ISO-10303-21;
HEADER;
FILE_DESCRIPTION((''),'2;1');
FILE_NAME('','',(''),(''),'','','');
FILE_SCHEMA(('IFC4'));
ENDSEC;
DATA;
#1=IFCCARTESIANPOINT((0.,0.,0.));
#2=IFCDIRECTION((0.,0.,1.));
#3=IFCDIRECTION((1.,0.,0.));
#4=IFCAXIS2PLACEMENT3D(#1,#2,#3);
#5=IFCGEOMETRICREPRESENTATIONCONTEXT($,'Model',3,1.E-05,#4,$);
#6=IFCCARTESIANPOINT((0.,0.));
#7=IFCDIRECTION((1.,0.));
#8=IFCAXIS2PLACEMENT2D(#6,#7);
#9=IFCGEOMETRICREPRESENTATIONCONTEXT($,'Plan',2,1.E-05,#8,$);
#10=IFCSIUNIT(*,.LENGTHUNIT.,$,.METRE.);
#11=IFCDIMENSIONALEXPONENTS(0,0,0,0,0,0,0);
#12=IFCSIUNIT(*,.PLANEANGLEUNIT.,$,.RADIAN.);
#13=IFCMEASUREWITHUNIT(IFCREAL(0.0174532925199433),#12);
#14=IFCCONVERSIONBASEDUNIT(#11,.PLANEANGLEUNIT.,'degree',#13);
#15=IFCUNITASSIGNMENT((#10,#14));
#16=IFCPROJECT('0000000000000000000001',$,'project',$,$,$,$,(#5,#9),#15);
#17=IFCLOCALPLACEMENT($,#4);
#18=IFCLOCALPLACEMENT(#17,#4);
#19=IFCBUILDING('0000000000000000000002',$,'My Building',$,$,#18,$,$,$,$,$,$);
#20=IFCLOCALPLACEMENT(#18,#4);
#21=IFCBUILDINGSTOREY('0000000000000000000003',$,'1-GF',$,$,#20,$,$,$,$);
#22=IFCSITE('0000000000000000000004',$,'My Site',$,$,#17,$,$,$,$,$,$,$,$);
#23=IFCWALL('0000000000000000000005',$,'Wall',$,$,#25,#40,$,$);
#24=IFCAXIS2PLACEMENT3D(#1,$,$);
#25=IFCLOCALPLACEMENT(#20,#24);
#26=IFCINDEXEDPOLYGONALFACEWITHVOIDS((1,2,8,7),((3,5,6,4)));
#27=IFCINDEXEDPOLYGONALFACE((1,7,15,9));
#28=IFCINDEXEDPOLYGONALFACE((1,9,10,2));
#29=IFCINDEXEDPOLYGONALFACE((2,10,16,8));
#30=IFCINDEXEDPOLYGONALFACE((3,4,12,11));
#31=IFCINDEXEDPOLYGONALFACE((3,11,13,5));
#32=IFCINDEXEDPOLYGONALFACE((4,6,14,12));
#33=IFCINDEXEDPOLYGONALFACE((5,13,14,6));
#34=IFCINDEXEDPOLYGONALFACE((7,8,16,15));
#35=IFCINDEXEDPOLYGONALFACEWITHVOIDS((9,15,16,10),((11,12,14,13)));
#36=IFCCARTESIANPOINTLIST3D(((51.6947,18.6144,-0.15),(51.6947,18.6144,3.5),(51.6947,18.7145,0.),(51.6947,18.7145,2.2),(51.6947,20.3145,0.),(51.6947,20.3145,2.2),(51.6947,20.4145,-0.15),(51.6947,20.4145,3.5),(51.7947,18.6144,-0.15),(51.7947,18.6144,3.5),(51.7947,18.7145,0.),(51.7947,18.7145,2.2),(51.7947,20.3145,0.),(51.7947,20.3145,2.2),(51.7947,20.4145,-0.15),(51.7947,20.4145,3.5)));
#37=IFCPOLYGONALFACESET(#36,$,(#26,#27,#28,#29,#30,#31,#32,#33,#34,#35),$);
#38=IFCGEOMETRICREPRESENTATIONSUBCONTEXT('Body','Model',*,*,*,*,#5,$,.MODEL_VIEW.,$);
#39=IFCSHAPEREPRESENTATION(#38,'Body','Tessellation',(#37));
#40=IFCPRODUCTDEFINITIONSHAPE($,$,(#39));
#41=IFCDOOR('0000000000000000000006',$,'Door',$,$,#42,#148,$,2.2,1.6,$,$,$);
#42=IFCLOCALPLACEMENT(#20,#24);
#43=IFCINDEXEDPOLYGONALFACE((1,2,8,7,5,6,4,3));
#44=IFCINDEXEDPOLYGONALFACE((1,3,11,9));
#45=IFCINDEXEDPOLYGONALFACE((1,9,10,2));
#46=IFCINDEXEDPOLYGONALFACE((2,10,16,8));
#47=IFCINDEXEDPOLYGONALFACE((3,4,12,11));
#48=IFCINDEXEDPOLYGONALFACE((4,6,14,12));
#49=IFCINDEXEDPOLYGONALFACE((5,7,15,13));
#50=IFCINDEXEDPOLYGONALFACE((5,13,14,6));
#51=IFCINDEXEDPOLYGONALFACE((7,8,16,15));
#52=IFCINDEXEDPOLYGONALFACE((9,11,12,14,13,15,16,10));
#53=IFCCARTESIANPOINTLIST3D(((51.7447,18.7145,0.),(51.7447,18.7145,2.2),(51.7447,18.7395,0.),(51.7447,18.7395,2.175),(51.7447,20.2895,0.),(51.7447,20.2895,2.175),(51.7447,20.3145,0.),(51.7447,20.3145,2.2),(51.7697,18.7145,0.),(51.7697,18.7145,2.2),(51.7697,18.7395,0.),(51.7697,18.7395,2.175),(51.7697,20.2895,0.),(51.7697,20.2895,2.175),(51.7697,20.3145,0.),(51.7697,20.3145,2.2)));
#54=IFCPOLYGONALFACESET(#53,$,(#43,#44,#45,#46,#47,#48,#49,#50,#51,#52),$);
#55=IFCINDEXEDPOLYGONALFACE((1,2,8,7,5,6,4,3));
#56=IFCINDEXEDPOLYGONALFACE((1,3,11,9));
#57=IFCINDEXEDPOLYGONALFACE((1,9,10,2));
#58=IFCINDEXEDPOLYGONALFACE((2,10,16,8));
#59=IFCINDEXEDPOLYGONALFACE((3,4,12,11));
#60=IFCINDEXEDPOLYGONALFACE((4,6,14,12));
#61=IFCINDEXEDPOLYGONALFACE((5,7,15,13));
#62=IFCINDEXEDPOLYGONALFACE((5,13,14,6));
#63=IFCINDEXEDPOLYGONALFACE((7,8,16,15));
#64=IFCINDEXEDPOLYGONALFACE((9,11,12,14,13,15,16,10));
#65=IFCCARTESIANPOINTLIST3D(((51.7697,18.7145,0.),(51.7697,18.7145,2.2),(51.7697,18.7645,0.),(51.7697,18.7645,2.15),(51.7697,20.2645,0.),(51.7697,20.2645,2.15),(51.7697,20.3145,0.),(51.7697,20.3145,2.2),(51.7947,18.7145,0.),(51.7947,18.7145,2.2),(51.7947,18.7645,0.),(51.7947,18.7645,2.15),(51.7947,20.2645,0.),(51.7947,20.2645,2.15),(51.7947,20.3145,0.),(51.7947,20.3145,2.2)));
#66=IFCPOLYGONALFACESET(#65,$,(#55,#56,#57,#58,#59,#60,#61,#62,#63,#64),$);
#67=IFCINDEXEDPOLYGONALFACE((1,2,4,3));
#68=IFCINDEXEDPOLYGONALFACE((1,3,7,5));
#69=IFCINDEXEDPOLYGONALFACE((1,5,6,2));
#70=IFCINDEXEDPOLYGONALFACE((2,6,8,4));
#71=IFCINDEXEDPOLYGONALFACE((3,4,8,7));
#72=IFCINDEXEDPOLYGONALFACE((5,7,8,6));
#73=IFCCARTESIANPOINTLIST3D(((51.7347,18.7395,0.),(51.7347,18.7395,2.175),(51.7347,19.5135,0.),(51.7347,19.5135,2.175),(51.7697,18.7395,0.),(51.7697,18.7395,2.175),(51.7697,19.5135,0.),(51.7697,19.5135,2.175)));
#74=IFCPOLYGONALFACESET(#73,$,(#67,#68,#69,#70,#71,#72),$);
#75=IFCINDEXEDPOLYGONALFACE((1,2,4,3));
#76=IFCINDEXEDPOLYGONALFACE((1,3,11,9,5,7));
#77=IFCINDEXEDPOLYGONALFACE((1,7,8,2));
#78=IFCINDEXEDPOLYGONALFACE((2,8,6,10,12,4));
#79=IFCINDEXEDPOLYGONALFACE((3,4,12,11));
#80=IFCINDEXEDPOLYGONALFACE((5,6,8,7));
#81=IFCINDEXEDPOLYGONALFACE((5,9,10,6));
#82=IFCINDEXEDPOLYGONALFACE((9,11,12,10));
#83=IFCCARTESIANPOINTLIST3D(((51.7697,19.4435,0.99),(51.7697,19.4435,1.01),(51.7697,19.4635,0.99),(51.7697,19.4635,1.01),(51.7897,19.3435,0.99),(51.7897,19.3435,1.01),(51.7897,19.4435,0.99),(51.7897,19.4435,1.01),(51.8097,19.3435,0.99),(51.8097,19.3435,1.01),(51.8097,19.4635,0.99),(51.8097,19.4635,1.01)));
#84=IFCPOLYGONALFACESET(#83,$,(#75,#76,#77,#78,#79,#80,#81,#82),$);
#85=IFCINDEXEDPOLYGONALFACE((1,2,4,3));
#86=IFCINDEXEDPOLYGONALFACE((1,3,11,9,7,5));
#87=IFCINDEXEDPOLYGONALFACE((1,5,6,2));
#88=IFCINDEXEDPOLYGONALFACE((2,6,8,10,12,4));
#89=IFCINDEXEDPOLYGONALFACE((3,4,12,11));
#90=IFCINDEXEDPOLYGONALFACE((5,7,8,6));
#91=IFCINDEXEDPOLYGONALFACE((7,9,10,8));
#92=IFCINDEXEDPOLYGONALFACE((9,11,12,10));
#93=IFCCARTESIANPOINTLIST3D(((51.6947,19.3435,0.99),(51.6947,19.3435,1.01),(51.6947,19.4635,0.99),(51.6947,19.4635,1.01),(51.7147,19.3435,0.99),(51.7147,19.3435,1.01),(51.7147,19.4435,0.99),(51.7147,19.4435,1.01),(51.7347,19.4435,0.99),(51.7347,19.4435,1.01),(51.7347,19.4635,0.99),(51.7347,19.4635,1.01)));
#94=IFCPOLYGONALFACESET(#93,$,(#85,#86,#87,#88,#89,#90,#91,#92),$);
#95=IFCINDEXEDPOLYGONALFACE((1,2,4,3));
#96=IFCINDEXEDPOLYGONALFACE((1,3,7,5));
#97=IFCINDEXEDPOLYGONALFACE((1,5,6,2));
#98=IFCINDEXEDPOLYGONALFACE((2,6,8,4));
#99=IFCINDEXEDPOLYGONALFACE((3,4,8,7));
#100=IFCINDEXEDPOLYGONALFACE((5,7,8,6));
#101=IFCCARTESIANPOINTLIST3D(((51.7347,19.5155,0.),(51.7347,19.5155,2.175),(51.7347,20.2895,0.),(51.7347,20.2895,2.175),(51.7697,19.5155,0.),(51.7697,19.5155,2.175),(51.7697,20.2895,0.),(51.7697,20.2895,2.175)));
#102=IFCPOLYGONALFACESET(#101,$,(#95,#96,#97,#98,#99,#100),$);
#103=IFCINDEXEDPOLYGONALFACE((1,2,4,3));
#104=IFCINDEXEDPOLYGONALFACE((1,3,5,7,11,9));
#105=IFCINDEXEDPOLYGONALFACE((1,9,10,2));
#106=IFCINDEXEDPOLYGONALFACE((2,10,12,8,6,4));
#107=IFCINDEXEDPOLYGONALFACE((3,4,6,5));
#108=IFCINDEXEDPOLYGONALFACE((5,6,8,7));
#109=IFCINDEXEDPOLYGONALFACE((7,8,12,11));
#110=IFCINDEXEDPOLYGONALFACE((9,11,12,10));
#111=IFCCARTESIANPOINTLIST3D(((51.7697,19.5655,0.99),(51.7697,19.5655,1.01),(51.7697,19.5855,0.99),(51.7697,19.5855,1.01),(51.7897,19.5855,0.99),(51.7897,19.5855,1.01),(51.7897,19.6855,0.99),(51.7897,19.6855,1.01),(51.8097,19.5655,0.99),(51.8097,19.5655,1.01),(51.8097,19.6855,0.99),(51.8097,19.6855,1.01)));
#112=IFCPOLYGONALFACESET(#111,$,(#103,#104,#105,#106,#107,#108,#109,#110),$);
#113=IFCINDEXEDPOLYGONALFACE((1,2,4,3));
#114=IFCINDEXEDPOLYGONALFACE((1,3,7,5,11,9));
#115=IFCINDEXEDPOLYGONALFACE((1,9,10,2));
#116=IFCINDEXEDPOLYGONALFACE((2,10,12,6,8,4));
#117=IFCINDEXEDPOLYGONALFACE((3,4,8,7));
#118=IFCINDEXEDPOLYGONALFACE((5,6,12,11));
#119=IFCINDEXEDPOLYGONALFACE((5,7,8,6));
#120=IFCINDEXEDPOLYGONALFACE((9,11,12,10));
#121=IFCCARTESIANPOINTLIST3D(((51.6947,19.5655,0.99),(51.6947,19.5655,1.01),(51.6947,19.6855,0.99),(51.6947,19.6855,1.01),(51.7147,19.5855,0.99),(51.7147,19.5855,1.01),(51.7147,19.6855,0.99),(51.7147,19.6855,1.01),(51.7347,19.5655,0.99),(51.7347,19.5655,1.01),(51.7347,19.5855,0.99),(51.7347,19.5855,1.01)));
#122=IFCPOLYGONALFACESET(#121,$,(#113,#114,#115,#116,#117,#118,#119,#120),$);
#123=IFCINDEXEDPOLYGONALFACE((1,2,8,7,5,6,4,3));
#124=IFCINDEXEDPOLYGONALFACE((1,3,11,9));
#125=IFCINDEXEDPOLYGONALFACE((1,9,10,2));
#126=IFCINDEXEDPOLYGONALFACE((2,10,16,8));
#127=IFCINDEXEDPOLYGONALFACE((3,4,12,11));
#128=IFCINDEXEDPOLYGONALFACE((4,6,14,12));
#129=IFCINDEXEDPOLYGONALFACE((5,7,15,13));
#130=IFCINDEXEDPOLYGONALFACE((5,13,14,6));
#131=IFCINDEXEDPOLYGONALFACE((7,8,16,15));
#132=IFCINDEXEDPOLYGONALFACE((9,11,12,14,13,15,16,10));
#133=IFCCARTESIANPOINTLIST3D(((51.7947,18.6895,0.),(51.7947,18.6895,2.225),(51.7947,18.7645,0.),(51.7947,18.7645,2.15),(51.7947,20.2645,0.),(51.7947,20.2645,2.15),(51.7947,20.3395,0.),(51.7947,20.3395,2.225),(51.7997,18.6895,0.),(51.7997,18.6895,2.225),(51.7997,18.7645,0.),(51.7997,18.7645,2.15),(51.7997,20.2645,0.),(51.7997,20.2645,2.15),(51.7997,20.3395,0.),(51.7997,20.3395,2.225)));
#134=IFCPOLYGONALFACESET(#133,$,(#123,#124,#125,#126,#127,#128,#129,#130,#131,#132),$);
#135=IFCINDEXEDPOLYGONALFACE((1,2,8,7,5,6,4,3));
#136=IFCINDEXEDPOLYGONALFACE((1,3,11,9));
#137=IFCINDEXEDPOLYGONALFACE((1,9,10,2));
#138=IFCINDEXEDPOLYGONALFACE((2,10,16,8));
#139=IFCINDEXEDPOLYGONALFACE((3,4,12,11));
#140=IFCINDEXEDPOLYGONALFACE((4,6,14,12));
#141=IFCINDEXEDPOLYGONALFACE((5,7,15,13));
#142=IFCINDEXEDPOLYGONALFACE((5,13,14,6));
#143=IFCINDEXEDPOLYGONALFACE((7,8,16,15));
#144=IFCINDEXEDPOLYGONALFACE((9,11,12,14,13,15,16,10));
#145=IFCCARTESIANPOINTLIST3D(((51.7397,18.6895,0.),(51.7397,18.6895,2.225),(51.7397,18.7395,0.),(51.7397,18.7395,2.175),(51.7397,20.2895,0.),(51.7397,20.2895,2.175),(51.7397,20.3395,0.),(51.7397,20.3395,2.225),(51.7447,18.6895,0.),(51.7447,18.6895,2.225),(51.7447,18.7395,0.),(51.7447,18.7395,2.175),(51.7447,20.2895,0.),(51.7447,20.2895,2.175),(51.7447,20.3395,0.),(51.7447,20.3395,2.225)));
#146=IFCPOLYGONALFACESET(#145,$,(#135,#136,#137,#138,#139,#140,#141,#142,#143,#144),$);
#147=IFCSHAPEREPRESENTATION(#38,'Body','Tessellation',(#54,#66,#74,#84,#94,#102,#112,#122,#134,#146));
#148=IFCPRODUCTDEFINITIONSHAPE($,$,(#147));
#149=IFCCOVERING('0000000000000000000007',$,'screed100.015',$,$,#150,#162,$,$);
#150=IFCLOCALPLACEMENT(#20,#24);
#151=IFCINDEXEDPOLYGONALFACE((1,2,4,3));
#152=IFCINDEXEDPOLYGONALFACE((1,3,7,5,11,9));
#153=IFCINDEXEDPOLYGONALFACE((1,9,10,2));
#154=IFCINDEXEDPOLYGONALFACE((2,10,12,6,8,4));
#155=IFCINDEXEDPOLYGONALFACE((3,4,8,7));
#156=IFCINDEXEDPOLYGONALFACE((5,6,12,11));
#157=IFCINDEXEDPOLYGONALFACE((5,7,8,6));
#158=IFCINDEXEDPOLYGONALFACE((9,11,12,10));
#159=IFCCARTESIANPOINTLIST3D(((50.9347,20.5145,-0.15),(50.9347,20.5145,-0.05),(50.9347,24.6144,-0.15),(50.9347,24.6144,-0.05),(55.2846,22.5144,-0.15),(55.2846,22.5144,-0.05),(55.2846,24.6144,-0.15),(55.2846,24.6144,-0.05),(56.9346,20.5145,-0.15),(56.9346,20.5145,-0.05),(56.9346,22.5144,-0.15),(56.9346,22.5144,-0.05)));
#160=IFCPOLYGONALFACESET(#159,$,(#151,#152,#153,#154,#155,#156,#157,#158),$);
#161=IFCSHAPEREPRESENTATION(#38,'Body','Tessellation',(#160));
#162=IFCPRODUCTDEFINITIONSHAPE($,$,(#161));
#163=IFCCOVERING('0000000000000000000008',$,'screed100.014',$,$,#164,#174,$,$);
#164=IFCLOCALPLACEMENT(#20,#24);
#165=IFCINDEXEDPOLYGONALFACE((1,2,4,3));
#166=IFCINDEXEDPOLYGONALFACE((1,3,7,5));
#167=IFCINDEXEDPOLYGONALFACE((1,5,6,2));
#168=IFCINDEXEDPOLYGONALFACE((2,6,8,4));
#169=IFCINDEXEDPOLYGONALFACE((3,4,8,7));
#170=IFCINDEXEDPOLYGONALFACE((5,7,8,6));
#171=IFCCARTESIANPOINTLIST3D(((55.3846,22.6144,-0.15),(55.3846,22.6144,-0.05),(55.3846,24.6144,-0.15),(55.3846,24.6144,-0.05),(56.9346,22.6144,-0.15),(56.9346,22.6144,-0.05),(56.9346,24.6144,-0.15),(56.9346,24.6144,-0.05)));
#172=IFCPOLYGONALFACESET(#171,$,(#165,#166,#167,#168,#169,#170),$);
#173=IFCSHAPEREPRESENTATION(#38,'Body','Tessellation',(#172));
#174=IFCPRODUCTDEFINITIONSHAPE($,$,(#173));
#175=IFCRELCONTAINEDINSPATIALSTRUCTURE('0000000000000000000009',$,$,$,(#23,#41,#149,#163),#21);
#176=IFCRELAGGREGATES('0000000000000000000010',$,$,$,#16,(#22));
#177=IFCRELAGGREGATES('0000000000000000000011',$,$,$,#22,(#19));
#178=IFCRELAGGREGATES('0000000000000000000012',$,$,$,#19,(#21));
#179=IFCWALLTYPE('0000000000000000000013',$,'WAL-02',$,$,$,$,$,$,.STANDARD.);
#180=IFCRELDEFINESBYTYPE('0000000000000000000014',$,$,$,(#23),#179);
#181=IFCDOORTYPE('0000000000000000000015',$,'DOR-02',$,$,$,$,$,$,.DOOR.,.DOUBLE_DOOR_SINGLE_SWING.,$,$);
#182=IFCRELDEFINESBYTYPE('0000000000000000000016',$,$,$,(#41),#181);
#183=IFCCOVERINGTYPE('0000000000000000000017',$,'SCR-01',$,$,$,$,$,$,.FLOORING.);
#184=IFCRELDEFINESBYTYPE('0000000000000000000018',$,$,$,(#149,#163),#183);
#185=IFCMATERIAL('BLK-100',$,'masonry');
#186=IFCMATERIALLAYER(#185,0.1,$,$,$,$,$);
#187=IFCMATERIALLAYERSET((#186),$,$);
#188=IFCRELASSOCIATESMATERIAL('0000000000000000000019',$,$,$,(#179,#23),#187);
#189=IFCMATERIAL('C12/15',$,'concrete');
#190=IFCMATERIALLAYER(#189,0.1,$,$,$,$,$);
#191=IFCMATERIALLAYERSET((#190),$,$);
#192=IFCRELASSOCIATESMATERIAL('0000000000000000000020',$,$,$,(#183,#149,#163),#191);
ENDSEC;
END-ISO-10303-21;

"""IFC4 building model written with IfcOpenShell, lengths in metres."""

from ifc_helpers import new_model, entity, si_unit, converted_unit, frame, origin_with_axes, origin_2d_with_axis, place, context, subcontext, project, spatial, line, indexed_curve, outline, extrude, shape, source, transform, mapped, material, layer, layer_set, layer_usage, type_object, type_shapes, element, fill, save


model = new_model("IFC4")

# Units and contexts
model_context = context("Model", 3, precision=1e-05, world=origin_with_axes())
plan_context = context("Plan", 2, precision=1e-05, world=origin_2d_with_axis())
body_context_1 = subcontext(model_context, "Body", "Model", "MODEL_VIEW")
body_context_2 = subcontext(plan_context, "Body", "Plan", "PLAN_VIEW")
ifc_project = project(units=[si_unit("LENGTHUNIT", "METRE"), converted_unit("PLANEANGLEUNIT", "degree", entity("IfcReal", 0.0174532925199433), si_unit("PLANEANGLEUNIT", "RADIAN"), dimensions=[0, 0, 0, 0, 0, 0, 0])], contexts=[model_context, plan_context])

# Site, building, storey
site_placement = place(None, origin_with_axes())
site = spatial("IfcSite", under=ifc_project, at=site_placement, Name="My Site")
building_placement = place(site_placement, origin_with_axes())
building = spatial("IfcBuilding", under=site, at=building_placement, Name="My Building")
storey_placement = place(building_placement, origin_with_axes())
storey = spatial("IfcBuildingStorey", under=building, at=storey_placement, Name="1-GF")

# Shared definitions
ifc_material_1 = material(Name="BLK-100", Category="masonry")
ifc_layer_1 = layer(ifc_material_1, 0.1)
ifc_layer_set_1 = layer_set([ifc_layer_1])
wall_type_1 = type_object("IfcWallType", Name="WAL-02", PredefinedType="STANDARD", material=ifc_layer_set_1)

# Wall, opening, door
ifc_layer_usage_1 = layer_usage(ifc_layer_set_1, "AXIS2", "POSITIVE", 0.0)
wall_1_placement = place(storey_placement, frame((51.7947, 18.6144, -0.15), z_axis=(0.0, 0.0, 1.0), x_axis=(0.0, 1.0, 0.0)))
wall_1 = element("IfcWall", 1, at=wall_1_placement, inside=storey, type_object=wall_type_1, material=ifc_layer_usage_1, Name="Wall", context=body_context_1, shape_type="SweptSolid", body=[
    extrude(outline(indexed_curve([(0.0, 0.0), (0.0, 0.1), (1.8001, 0.1), (1.8001, 0.0), (0.0, 0.0)], self_intersect=False)), origin_with_axes(), (0.0, 0.0, 1.0), 3.65),
])
shared_shape_1 = source(origin_with_axes(), body_context_1, "Body", "SweptSolid", [
    extrude(outline(indexed_curve([(0.0, 0.0), (1.6, 0.0), (1.6, 2.2), (0.0, 2.2)], segments=[line(1, 2, 3, 4, 1)])), frame((0.0, -0.1, 0.0), z_axis=(0.0, -1.0, 0.0), x_axis=(1.0, 0.0, 0.0)), (0.0, 0.0, -1.0), 0.4),
])
opening_1_placement = place(wall_1_placement, frame((0.1001, 0.0, 0.15), z_axis=(0.0, 0.0, 1.0), x_axis=(1.0, 0.0, 0.0)))
opening_1 = element("IfcOpeningElement", 2, at=opening_1_placement, cuts=wall_1, PredefinedType="OPENING", context=body_context_1, shape_type="MappedRepresentation", body=[
    mapped(shared_shape_1, transform((0.0, 0.0, 0.0), x_axis=(1.0, 0.0, 0.0), y_axis=(0.0, 1.0, 0.0), z_axis=(0.0, 0.0, 1.0), scale=1.0)),
])
door_type_1 = type_object("IfcDoorType", Name="DOR-02", OperationType="DOUBLE_DOOR_SINGLE_SWING", PredefinedType="DOOR")
shared_shape_2 = source(origin_with_axes(), body_context_1, "Body", "SweptSolid", [
    extrude(outline(indexed_curve([(0.0, 0.0), (0.0, 2.2), (1.6, 2.2), (1.6, 0.0), (1.575, 0.0), (1.575, 2.175), (0.025, 2.175), (0.025, 0.0)], segments=[line(1, 2, 3, 4, 5, 6, 7, 8, 1)])), frame((0.0, 0.025, 0.0), z_axis=(0.0, -1.0, 0.0), x_axis=(1.0, 0.0, 0.0)), (0.0, 0.0, -1.0), 0.025),
    extrude(outline(indexed_curve([(0.0, 0.0), (0.0, 2.2), (1.6, 2.2), (1.6, 0.0), (1.55, 0.0), (1.55, 2.15), (0.05, 2.15), (0.05, 0.0)], segments=[line(1, 2, 3, 4, 5, 6, 7, 8, 1)])), frame((0.0, 0.0, 0.0), z_axis=(0.0, -1.0, 0.0), x_axis=(1.0, 0.0, 0.0)), (0.0, 0.0, -1.0), 0.025),
    extrude(outline(indexed_curve([(0.0, 0.0), (0.774, 0.0), (0.774, 0.035), (0.0, 0.035)], segments=[line(1, 2, 3, 4, 1)])), frame((0.025, 0.025, 0.0), z_axis=(0.0, 0.0, 1.0), x_axis=(1.0, 0.0, 0.0)), (0.0, 0.0, 1.0), 2.175),
    extrude(outline(indexed_curve([(0.0, 0.0), (0.0, -0.04), (-0.12, -0.04), (-0.12, -0.02), (-0.02, -0.02), (-0.02, 0.0)], segments=[line(1, 2, 3, 4, 5, 6, 1)])), frame((0.749, 0.025, 0.99), z_axis=(0.0, 0.0, 1.0), x_axis=(1.0, 0.0, 0.0)), (0.0, 0.0, 1.0), 0.02),
    extrude(outline(indexed_curve([(0.0, 0.0), (0.0, 0.04), (-0.12, 0.04), (-0.12, 0.02), (-0.02, 0.02), (-0.02, 0.0)], segments=[line(1, 2, 3, 4, 5, 6, 1)])), frame((0.749, 0.06, 0.99), z_axis=(0.0, 0.0, 1.0), x_axis=(1.0, 0.0, 0.0)), (0.0, 0.0, 1.0), 0.02),
    extrude(outline(indexed_curve([(0.0, 0.0), (-0.774, 0.0), (-0.774, 0.035), (0.0, 0.035)], segments=[line(1, 2, 3, 4, 1)])), frame((1.575, 0.025, 0.0), z_axis=(0.0, 0.0, 1.0), x_axis=(1.0, 0.0, 0.0)), (0.0, 0.0, 1.0), 2.175),
    extrude(outline(indexed_curve([(0.0, 0.0), (0.0, -0.04), (0.12, -0.04), (0.12, -0.02), (0.02, -0.02), (0.02, 0.0)], segments=[line(1, 2, 3, 4, 5, 6, 1)])), frame((0.851, 0.025, 0.99), z_axis=(0.0, 0.0, 1.0), x_axis=(1.0, 0.0, 0.0)), (0.0, 0.0, 1.0), 0.02),
    extrude(outline(indexed_curve([(0.0, 0.0), (0.0, 0.04), (0.12, 0.04), (0.12, 0.02), (0.02, 0.02), (0.02, 0.0)], segments=[line(1, 2, 3, 4, 5, 6, 1)])), frame((0.851, 0.06, 0.99), z_axis=(0.0, 0.0, 1.0), x_axis=(1.0, 0.0, 0.0)), (0.0, 0.0, 1.0), 0.02),
    extrude(outline(indexed_curve([(0.0, 0.0), (0.0, 2.225), (1.65, 2.225), (1.65, 0.0), (1.575, 0.0), (1.575, 2.15), (0.075, 2.15), (0.075, 0.0)], segments=[line(1, 2, 3, 4, 5, 6, 7, 8, 1)])), frame((-0.025, -0.005, 0.0), z_axis=(0.0, -1.0, 0.0), x_axis=(1.0, 0.0, 0.0)), (0.0, 0.0, -1.0), 0.005),
    extrude(outline(indexed_curve([(0.0, 0.0), (0.0, 2.225), (1.65, 2.225), (1.65, 0.0), (1.6, 0.0), (1.6, 2.175), (0.05, 2.175), (0.05, 0.0)], segments=[line(1, 2, 3, 4, 5, 6, 7, 8, 1)])), frame((-0.025, 0.05, 0.0), z_axis=(0.0, -1.0, 0.0), x_axis=(1.0, 0.0, 0.0)), (0.0, 0.0, -1.0), 0.005),
])
shared_shape_3 = source(origin_with_axes(), body_context_2, "Body", "Curve2D", [
    entity("IfcIndexedPolyCurve", entity("IfcCartesianPointList2D", [[0.0, 0.0], [0.0, 0.05], [0.025, 0.05], [0.025, 0.025], [0.05, 0.025], [0.05, 0.0]]), [entity("IfcLineIndex", [1, 2, 3, 4, 5, 6, 1])]),
    entity("IfcIndexedPolyCurve", entity("IfcCartesianPointList2D", [[1.6, 0.0], [1.6, 0.05], [1.575, 0.05], [1.575, 0.025], [1.55, 0.025], [1.55, 0.0]]), [entity("IfcLineIndex", [1, 2, 3, 4, 5, 6, 1])]),
    entity("IfcTrimmedCurve", entity("IfcEllipse", entity("IfcAxis2Placement2D", entity("IfcCartesianPoint", [0.06, 0.05]), entity("IfcDirection", [1.0, 0.0])), 0.74, 0.775), [entity("IfcCartesianPoint", [0.8, 0.05])], [entity("IfcCartesianPoint", [0.06, 0.825])], True, "CARTESIAN"),
    entity("IfcIndexedPolyCurve", entity("IfcCartesianPointList2D", [[0.025, 0.05], [0.06, 0.05], [0.06, 0.825], [0.025, 0.825]]), [entity("IfcLineIndex", [1, 2, 3, 4, 1])]),
    entity("IfcTrimmedCurve", entity("IfcEllipse", entity("IfcAxis2Placement2D", entity("IfcCartesianPoint", [1.54, 0.05]), entity("IfcDirection", [1.0, 0.0])), 0.74, 0.775), [entity("IfcCartesianPoint", [1.54, 0.825])], [entity("IfcCartesianPoint", [0.8, 0.05])], True, "CARTESIAN"),
    entity("IfcIndexedPolyCurve", entity("IfcCartesianPointList2D", [[1.575, 0.05], [1.54, 0.05], [1.54, 0.825], [1.575, 0.825]]), [entity("IfcLineIndex", [1, 2, 3, 4, 1])]),
])
type_shapes(door_type_1, [shared_shape_2, shared_shape_3])
door_1_placement = place(opening_1_placement, frame((0.0, 0.0, 0.0), z_axis=(0.0, 0.0, 1.0), x_axis=(1.0, 0.0, 0.0)))
door_1 = element("IfcDoor", 3, at=door_1_placement, inside=storey, type_object=door_type_1, Name="Door", OverallHeight=2.2, OverallWidth=1.6, shapes=[
    shape(body_context_1, "Body", "MappedRepresentation", [mapped(shared_shape_2, transform((0.0, 0.0, 0.0), x_axis=(1.0, 0.0, 0.0), y_axis=(0.0, 1.0, 0.0), z_axis=(0.0, 0.0, 1.0), scale=1.0))]),
    shape(body_context_2, "Body", "MappedRepresentation", [mapped(shared_shape_3, transform((0.0, 0.0, 0.0), x_axis=(1.0, 0.0, 0.0), y_axis=(0.0, 1.0, 0.0), z_axis=(0.0, 0.0, 1.0), scale=1.0))]),
])
fill(opening_1, door_1)

# Coverings
ifc_material_2 = material(Name="C12/15", Category="concrete")
ifc_layer_2 = layer(ifc_material_2, 0.1)
ifc_layer_set_2 = layer_set([ifc_layer_2])
ifc_layer_usage_2 = layer_usage(ifc_layer_set_2, "AXIS3", "POSITIVE", 0.0)
covering_type_1 = type_object("IfcCoveringType", Name="SCR-01", PredefinedType="FLOORING", material=ifc_layer_set_2)
covering_1_placement = place(storey_placement, frame((50.9347, 20.5145, -0.15), z_axis=(0.0, 0.0, 1.0), x_axis=(1.0, 0.0, 0.0)))
element("IfcCovering", 4, at=covering_1_placement, inside=storey, type_object=covering_type_1, material=ifc_layer_usage_2, Name="screed100.015", context=body_context_1, shape_type="SweptSolid", body=[
    extrude(outline(indexed_curve([(0.0, 0.0), (5.9999, 0.0), (4.3499, 4.0999), (0.0, 4.0999), (4.3499, 1.9999), (5.9999, 1.9999)], segments=[line(5, 3), line(3, 4), line(4, 1), line(1, 2), line(2, 6), line(6, 5)], self_intersect=False)), None, (0.0, 0.0, 1.0), 0.1),
])
ifc_layer_usage_3 = layer_usage(ifc_layer_set_2, "AXIS3", "POSITIVE", 0.0)
covering_2_placement = place(storey_placement, frame((55.3846, 22.6144, -0.15), z_axis=(0.0, 0.0, 1.0), x_axis=(1.0, 0.0, 0.0)))
element("IfcCovering", 5, at=covering_2_placement, inside=storey, type_object=covering_type_1, material=ifc_layer_usage_3, Name="screed100.014", context=body_context_1, shape_type="SweptSolid", body=[
    extrude(outline(indexed_curve([(0.0, 0.0), (1.55, 0.0), (1.55, 2.0), (0.0, 2.0)], segments=[line(3, 2), line(2, 1), line(1, 4), line(4, 3)], self_intersect=False)), None, (0.0, 0.0, 1.0), 0.1),
])

save(model, "model.ifc")
